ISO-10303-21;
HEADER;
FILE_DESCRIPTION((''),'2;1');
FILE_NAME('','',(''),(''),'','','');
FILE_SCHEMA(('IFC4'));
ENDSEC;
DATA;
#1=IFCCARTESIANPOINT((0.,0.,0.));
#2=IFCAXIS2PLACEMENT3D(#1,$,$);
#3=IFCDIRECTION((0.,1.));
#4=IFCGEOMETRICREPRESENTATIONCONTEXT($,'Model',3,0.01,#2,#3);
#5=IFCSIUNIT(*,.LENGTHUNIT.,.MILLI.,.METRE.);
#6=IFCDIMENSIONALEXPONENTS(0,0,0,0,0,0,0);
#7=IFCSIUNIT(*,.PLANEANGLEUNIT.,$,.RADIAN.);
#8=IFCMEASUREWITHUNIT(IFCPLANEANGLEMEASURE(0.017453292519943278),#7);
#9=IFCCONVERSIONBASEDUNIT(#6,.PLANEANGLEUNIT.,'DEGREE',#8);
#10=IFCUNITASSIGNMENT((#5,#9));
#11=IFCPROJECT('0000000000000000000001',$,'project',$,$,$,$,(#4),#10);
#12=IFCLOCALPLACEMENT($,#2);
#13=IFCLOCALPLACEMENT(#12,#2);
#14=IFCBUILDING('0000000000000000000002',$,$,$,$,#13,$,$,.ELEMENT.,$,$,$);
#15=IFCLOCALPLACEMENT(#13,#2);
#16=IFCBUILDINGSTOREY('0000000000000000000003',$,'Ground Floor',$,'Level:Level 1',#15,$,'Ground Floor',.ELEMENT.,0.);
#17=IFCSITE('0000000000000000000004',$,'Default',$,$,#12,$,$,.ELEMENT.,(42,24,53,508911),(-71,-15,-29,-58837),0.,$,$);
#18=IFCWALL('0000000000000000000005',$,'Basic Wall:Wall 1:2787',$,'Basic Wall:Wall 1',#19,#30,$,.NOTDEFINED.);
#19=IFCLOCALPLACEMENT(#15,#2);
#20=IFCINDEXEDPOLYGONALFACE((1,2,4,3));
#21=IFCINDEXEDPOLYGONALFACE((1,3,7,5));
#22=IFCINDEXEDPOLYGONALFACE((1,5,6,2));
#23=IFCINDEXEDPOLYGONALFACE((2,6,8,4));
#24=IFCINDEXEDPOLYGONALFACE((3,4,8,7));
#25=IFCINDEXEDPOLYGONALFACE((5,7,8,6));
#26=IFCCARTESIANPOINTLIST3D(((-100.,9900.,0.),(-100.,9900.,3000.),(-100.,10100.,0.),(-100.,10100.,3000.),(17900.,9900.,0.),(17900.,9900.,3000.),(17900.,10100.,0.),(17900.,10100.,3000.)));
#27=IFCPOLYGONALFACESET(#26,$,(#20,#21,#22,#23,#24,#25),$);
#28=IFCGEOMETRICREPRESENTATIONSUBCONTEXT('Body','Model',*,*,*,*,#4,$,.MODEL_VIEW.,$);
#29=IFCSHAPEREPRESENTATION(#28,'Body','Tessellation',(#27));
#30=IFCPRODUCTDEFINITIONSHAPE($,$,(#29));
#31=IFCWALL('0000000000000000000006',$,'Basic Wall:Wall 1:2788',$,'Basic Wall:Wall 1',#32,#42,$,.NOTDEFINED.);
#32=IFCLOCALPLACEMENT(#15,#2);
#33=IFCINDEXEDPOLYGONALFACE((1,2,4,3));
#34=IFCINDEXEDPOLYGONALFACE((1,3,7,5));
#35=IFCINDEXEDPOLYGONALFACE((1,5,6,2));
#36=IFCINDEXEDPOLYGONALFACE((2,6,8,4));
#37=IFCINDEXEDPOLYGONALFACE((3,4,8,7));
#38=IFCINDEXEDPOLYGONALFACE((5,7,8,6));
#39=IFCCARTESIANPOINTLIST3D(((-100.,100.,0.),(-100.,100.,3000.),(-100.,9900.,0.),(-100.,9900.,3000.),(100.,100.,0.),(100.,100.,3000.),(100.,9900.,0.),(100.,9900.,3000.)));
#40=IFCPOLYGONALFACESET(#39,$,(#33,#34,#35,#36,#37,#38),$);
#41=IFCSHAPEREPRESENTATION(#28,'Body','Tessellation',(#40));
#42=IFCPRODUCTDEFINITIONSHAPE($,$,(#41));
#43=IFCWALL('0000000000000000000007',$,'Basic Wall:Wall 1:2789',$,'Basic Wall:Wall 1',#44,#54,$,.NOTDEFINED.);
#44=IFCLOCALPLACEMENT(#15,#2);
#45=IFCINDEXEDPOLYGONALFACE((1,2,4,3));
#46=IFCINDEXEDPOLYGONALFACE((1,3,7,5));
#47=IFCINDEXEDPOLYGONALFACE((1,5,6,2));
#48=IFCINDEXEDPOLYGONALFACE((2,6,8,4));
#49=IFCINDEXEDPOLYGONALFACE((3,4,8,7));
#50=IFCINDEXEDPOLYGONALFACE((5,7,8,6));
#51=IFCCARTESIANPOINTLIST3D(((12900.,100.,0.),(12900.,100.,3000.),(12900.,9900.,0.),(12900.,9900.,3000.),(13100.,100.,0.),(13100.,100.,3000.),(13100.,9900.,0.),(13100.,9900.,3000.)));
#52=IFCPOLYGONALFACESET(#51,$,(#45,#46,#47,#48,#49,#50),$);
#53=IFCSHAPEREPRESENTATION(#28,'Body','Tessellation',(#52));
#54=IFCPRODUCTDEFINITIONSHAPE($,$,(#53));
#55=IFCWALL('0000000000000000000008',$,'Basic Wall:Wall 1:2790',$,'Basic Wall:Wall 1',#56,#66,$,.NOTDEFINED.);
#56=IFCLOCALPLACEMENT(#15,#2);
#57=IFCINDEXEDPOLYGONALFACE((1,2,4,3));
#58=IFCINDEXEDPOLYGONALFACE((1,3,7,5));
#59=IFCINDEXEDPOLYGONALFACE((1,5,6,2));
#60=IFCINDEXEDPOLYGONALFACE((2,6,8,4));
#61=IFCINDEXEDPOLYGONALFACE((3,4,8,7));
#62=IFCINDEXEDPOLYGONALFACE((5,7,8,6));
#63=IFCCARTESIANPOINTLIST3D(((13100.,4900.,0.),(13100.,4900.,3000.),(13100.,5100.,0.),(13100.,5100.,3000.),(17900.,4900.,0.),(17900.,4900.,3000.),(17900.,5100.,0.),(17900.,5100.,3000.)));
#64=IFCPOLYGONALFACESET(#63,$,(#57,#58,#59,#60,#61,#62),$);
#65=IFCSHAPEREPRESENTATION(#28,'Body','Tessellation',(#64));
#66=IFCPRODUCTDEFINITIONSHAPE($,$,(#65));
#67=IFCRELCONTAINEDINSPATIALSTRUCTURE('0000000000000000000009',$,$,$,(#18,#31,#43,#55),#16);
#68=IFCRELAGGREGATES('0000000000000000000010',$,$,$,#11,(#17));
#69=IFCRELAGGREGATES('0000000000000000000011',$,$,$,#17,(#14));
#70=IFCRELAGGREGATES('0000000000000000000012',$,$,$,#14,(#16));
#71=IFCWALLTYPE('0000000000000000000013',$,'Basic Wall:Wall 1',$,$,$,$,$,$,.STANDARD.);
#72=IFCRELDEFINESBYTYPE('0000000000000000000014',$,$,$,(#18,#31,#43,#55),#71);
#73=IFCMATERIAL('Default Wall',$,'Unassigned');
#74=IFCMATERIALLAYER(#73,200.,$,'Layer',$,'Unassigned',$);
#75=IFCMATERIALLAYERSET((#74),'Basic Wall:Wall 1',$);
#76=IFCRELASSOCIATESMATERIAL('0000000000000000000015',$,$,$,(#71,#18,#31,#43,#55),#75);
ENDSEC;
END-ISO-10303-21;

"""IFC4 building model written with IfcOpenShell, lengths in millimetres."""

from ifc_helpers import new_model, entity, si_unit, converted_unit, direction, frame, frame_2d, origin, place, context, subcontext, project, spatial, rectangle, extrude, material, layer, layer_set, layer_usage, type_object, element, save


model = new_model("IFC4")

# Units and contexts
model_context = context("Model", 3, precision=0.01, world=origin(), true_north=direction((0.0, 1.0)))
body_context = subcontext(model_context, "Body", "Model", "MODEL_VIEW")
ifc_project = project(units=[si_unit("LENGTHUNIT", "METRE", prefix="MILLI"), converted_unit("PLANEANGLEUNIT", "DEGREE", entity("IfcPlaneAngleMeasure", 0.017453292519943278), si_unit("PLANEANGLEUNIT", "RADIAN"), dimensions=[0, 0, 0, 0, 0, 0, 0])], contexts=[model_context])

# Site, building, storey
site_placement = place(None, origin())
site = spatial("IfcSite", under=ifc_project, at=site_placement, Name="Default", CompositionType="ELEMENT", RefLatitude=(42, 24, 53, 508911), RefLongitude=(-71, -15, -29, -58837), RefElevation=0.0)
building_placement = place(site_placement, origin())
building = spatial("IfcBuilding", under=site, at=building_placement, CompositionType="ELEMENT")
storey_placement = place(building_placement, origin())
storey = spatial("IfcBuildingStorey", under=building, at=storey_placement, Name="Ground Floor", ObjectType="Level:Level 1", LongName="Ground Floor", CompositionType="ELEMENT", Elevation=0.0)

# Shared definitions
ifc_material_1 = material(Name="Default Wall", Category="Unassigned")

# Walls
ifc_layer_1 = layer(ifc_material_1, 200.0, Name="Layer", Category="Unassigned")
ifc_layer_set_1 = layer_set([ifc_layer_1], Name="Basic Wall:Wall 1")
wall_type = type_object("IfcWallType", Name="Basic Wall:Wall 1", PredefinedType="STANDARD", material=ifc_layer_set_1)
ifc_layer_usage_1 = layer_usage(ifc_layer_set_1, "AXIS2", "NEGATIVE", 100.0)
wall_1_placement = place(storey_placement, frame((17900.0, 10000.0, 0.0), z_axis=(0.0, 0.0, 1.0), x_axis=(-1.0, 0.0, 0.0)))
element("IfcWall", 1, at=wall_1_placement, inside=storey, type_object=wall_type, material=ifc_layer_usage_1, Name="Basic Wall:Wall 1:2787", ObjectType="Basic Wall:Wall 1", PredefinedType="NOTDEFINED", context=body_context, shape_type="SweptSolid", body=[
    extrude(rectangle(XDim=18000.0, YDim=200.0, at=frame_2d((9000.0, 0.0), x_axis=(-1.0, 0.0))), origin(), (0.0, 0.0, 1.0), 3000.0),
])
ifc_layer_usage_2 = layer_usage(ifc_layer_set_1, "AXIS2", "NEGATIVE", 100.0)
wall_2_placement = place(storey_placement, frame((0.0, 9900.0, 0.0), z_axis=(0.0, 0.0, 1.0), x_axis=(0.0, -1.0, 0.0)))
element("IfcWall", 2, at=wall_2_placement, inside=storey, type_object=wall_type, material=ifc_layer_usage_2, Name="Basic Wall:Wall 1:2788", ObjectType="Basic Wall:Wall 1", PredefinedType="NOTDEFINED", context=body_context, shape_type="SweptSolid", body=[
    extrude(rectangle(XDim=9800.0, YDim=200.0, at=frame_2d((4900.0, 0.0), x_axis=(-1.0, 0.0))), origin(), (0.0, 0.0, 1.0), 3000.0),
])
ifc_layer_usage_3 = layer_usage(ifc_layer_set_1, "AXIS2", "NEGATIVE", 100.0)
wall_3_placement = place(storey_placement, frame((13000.0, 100.0, 0.0), z_axis=(0.0, 0.0, 1.0), x_axis=(0.0, 1.0, 0.0)))
element("IfcWall", 3, at=wall_3_placement, inside=storey, type_object=wall_type, material=ifc_layer_usage_3, Name="Basic Wall:Wall 1:2789", ObjectType="Basic Wall:Wall 1", PredefinedType="NOTDEFINED", context=body_context, shape_type="SweptSolid", body=[
    extrude(rectangle(XDim=9800.0, YDim=200.0, at=frame_2d((4900.0, 0.0), x_axis=(-1.0, 0.0))), origin(), (0.0, 0.0, 1.0), 3000.0),
])
ifc_layer_usage_4 = layer_usage(ifc_layer_set_1, "AXIS2", "NEGATIVE", 100.0)
wall_4_placement = place(storey_placement, frame((13100.0, 5000.0, 0.0)))
element("IfcWall", 4, at=wall_4_placement, inside=storey, type_object=wall_type, material=ifc_layer_usage_4, Name="Basic Wall:Wall 1:2790", ObjectType="Basic Wall:Wall 1", PredefinedType="NOTDEFINED", context=body_context, shape_type="SweptSolid", body=[
    extrude(rectangle(XDim=4800.0, YDim=200.0, at=frame_2d((2400.0, 0.0), x_axis=(-1.0, 0.0))), origin(), (0.0, 0.0, 1.0), 3000.0),
])

save(model, "model.ifc")
